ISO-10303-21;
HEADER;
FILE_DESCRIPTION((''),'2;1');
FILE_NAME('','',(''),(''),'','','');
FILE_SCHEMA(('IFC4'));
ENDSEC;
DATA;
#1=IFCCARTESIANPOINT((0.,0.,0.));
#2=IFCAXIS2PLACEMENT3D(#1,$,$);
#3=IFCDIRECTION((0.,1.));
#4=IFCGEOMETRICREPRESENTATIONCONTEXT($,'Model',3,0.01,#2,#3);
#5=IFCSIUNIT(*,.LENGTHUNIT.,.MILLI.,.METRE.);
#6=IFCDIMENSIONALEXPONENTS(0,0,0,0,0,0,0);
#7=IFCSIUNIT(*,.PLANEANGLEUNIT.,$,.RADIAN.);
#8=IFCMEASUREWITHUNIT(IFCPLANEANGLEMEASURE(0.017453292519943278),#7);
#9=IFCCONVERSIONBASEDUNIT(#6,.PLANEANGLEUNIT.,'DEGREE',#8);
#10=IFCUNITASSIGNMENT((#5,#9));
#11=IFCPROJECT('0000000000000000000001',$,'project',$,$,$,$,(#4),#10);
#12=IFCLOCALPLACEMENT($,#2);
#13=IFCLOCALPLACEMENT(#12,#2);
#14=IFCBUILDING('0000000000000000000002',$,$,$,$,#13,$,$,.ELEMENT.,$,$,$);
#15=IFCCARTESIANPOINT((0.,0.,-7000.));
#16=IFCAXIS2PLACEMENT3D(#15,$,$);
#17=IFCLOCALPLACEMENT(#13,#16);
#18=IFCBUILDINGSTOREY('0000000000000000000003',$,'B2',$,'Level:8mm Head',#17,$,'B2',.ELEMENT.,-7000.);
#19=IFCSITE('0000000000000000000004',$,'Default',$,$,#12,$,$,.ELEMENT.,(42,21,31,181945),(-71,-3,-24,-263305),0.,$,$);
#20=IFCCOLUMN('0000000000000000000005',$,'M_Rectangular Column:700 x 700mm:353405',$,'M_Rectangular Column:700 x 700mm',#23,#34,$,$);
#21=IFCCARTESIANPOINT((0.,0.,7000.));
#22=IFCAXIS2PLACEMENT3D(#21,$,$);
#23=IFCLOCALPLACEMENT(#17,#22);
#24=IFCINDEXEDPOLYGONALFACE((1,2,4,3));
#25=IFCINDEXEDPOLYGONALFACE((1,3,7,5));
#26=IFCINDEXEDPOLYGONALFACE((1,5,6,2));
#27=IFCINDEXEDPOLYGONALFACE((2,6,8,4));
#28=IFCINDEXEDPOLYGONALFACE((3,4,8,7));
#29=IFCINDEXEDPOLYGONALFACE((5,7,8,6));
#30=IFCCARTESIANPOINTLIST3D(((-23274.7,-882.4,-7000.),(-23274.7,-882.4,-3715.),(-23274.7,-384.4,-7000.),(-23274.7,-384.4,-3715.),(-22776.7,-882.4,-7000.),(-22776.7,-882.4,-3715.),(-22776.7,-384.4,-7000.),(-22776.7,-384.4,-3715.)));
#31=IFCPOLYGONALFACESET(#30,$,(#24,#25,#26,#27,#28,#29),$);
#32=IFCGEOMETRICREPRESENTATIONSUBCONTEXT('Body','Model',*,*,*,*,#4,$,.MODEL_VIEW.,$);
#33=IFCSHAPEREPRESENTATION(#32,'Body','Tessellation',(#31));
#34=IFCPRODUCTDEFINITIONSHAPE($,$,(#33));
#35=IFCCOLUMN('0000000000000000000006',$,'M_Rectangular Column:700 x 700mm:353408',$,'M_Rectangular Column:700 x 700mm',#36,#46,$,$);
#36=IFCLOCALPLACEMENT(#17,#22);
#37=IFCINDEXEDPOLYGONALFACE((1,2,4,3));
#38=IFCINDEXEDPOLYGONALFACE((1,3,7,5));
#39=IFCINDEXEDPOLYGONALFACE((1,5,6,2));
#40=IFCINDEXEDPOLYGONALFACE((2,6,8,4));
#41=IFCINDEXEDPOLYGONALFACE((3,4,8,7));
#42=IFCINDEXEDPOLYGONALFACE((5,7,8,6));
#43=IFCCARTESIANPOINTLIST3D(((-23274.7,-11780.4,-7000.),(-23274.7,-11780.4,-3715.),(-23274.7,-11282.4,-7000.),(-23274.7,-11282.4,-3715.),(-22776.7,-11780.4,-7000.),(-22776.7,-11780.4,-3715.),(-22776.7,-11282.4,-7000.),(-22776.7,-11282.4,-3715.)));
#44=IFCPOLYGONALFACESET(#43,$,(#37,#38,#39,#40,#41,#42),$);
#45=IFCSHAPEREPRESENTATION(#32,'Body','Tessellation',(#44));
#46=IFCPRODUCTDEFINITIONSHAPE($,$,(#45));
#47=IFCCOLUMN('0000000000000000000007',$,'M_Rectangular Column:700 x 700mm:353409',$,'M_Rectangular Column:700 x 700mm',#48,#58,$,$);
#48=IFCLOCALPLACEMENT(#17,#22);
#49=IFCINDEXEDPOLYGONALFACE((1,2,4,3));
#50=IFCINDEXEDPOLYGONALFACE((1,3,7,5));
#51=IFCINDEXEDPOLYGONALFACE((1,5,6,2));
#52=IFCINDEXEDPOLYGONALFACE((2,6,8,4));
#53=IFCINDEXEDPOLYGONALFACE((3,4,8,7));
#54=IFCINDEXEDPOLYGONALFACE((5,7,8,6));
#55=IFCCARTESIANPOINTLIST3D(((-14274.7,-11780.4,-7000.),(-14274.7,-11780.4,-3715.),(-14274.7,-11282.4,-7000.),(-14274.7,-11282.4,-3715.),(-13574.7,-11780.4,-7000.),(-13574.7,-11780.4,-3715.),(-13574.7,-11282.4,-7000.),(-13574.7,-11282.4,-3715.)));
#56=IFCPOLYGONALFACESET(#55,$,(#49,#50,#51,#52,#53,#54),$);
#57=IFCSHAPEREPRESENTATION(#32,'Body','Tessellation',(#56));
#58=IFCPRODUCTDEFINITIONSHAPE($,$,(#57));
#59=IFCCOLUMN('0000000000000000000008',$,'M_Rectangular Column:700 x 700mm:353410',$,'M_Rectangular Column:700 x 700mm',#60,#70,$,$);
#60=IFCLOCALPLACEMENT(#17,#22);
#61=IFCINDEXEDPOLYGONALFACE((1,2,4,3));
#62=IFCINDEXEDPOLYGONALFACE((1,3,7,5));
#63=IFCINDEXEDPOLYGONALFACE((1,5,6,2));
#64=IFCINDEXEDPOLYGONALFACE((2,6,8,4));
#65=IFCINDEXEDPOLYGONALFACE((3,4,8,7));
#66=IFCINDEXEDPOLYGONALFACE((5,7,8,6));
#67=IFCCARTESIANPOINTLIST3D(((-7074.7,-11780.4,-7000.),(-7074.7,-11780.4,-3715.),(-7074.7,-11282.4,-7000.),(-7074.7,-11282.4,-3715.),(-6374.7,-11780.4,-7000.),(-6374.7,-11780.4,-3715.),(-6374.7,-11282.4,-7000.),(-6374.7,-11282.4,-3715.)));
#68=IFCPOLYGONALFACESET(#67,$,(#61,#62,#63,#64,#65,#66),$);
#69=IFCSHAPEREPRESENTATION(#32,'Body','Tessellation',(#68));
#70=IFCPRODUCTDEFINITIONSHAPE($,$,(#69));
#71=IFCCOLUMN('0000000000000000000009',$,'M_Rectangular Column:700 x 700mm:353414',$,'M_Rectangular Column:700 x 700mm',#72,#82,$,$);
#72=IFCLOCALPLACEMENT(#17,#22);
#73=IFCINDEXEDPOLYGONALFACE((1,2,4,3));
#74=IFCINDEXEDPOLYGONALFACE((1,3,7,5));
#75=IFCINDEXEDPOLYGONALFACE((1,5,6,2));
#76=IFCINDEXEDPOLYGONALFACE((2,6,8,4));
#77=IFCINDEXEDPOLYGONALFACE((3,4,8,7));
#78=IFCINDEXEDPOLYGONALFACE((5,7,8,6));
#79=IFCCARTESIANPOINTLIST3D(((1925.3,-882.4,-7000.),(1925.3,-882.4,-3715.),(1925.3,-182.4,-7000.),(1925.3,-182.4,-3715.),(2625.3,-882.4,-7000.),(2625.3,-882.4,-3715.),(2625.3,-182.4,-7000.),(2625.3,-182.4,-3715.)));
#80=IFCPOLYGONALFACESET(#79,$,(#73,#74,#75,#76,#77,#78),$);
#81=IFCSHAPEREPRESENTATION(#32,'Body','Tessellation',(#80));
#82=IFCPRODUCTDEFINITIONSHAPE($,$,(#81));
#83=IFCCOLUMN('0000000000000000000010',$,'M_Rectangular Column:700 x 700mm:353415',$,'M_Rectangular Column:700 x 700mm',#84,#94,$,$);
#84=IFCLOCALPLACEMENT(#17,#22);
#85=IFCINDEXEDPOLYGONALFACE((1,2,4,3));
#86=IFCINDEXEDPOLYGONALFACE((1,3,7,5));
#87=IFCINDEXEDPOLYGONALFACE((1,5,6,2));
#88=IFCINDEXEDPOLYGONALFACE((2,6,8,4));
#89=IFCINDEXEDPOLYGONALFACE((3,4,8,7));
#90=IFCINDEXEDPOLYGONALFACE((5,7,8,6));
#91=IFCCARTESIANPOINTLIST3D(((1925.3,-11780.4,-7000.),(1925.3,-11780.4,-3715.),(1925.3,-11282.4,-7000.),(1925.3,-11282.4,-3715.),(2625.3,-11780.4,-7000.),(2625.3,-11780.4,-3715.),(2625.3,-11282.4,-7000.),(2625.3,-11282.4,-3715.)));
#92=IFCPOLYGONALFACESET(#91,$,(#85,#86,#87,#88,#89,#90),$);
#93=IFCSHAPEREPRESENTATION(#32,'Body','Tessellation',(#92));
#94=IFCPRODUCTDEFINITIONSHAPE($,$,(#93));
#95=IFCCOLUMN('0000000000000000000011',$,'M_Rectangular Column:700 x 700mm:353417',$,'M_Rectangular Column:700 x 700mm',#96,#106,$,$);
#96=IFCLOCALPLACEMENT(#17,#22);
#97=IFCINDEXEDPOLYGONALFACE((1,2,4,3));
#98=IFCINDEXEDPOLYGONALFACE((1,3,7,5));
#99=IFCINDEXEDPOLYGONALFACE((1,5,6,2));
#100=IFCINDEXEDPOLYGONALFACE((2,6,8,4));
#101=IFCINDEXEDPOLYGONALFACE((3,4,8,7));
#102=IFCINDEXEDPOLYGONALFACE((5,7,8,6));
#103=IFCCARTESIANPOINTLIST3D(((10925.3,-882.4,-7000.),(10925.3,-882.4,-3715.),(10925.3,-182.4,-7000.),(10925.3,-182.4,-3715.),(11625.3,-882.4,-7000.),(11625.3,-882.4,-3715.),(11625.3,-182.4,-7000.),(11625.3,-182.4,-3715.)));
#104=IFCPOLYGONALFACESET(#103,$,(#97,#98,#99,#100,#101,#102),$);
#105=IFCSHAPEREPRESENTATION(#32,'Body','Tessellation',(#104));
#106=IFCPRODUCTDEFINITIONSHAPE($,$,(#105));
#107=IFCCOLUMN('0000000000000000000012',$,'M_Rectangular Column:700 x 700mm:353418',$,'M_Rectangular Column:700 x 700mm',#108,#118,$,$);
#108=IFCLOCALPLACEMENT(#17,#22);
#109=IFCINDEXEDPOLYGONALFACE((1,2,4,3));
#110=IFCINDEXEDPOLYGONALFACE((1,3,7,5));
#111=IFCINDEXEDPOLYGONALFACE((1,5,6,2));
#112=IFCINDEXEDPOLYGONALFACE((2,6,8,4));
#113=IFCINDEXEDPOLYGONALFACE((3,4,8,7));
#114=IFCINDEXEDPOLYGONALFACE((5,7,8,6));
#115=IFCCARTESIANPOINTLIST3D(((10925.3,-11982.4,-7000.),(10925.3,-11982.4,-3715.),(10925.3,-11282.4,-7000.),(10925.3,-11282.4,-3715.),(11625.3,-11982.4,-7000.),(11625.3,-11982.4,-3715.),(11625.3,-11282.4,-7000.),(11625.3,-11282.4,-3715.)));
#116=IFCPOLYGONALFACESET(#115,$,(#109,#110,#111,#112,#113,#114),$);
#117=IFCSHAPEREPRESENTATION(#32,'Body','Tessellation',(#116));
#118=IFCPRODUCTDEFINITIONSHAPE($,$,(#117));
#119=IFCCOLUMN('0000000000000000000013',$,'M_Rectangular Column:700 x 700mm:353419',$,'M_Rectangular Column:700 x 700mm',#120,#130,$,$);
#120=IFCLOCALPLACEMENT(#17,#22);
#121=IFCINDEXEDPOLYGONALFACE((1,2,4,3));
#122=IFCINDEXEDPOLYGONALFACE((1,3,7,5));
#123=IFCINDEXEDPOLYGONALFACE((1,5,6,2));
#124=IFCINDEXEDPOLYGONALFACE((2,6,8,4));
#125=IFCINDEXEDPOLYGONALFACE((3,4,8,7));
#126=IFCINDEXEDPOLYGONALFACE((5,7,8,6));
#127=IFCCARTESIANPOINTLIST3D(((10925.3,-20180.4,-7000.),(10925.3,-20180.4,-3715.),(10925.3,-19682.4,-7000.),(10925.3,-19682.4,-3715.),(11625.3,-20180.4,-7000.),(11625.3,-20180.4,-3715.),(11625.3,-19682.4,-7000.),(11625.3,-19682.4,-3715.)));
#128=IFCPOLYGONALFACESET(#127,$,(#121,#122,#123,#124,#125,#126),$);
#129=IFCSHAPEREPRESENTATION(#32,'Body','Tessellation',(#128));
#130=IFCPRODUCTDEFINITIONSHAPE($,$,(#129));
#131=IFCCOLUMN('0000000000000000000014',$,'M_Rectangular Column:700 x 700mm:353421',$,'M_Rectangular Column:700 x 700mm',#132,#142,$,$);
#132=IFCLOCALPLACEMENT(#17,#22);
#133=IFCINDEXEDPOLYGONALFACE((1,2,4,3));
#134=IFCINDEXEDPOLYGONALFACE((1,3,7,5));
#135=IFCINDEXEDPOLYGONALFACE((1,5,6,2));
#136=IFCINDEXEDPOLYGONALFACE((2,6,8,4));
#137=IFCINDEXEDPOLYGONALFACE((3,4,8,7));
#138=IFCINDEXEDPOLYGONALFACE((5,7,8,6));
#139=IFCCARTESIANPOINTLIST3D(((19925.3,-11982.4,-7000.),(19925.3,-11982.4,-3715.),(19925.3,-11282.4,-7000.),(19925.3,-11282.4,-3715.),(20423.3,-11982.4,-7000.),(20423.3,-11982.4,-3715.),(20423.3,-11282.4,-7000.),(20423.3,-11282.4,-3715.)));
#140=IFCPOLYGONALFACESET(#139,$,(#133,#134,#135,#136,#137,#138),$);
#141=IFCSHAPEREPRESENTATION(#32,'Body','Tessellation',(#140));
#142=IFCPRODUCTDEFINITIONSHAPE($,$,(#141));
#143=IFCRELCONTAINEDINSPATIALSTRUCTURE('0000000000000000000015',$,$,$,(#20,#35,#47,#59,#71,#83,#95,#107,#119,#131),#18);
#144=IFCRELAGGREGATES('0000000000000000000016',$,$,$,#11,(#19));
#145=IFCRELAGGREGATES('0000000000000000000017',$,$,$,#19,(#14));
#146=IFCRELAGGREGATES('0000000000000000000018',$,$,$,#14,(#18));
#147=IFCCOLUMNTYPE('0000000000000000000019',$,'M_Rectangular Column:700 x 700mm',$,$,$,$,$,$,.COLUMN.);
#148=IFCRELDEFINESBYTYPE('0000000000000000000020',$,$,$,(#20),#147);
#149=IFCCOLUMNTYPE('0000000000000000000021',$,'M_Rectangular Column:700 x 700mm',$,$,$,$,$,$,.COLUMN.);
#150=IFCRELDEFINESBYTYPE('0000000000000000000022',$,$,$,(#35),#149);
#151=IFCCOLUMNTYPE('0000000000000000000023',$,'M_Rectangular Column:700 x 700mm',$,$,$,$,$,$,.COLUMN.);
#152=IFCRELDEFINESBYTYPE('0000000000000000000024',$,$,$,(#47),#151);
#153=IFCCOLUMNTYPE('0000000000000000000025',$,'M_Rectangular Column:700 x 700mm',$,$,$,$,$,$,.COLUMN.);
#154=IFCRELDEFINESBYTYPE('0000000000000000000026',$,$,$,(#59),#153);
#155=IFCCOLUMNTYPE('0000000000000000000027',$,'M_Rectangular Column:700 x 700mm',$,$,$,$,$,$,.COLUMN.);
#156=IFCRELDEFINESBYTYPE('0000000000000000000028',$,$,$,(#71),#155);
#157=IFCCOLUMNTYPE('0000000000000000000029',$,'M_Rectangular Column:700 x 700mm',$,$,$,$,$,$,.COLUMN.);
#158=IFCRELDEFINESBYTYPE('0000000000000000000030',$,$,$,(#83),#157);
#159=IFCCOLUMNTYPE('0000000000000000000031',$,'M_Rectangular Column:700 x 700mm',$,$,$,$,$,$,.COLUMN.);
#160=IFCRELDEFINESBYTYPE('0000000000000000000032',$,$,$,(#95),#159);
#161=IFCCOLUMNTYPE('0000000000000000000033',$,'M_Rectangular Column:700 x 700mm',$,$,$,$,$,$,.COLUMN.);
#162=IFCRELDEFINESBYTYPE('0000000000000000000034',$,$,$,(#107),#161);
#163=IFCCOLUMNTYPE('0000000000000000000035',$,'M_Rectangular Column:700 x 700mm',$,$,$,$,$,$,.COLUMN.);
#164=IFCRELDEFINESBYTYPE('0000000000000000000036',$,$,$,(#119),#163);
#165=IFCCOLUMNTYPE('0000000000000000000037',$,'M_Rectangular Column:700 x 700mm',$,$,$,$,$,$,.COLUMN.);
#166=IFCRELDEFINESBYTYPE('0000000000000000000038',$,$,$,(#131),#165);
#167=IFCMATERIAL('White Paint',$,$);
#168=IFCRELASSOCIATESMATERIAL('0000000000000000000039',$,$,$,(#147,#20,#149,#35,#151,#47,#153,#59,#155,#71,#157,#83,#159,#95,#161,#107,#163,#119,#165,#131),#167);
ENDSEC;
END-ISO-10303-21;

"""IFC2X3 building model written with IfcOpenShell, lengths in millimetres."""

from ifc_helpers import new_model, entity, si_unit, converted_unit, direction, frame, frame_2d, origin, origin_2d_with_axis, place, context, subcontext, project, spatial, rectangle, extrude, source, transform, mapped, material, type_object, type_shapes, element, save


model = new_model("IFC2X3")

# Units and contexts
model_context = context("Model", 3, precision=0.01, world=origin(), true_north=direction((0.0, 1.0)))
body_context = subcontext(model_context, "Body", "Model", "MODEL_VIEW")
ifc_project = project(units=[si_unit("LENGTHUNIT", "METRE", prefix="MILLI"), converted_unit("PLANEANGLEUNIT", "DEGREE", entity("IfcPlaneAngleMeasure", 0.017453292519943278), si_unit("PLANEANGLEUNIT", "RADIAN"), dimensions=[0, 0, 0, 0, 0, 0, 0])], contexts=[model_context])

# Site, building, storey
site_placement = place(None, origin())
site = spatial("IfcSite", under=ifc_project, at=site_placement, Name="Default", CompositionType="ELEMENT", RefLatitude=(42, 21, 31, 181945), RefLongitude=(-71, -3, -24, -263305), RefElevation=0.0)
building_placement = place(site_placement, origin())
building = spatial("IfcBuilding", under=site, at=building_placement, CompositionType="ELEMENT")
storey_placement = place(building_placement, frame((0.0, 0.0, -7000.0)))
storey = spatial("IfcBuildingStorey", under=building, at=storey_placement, Name="B2", ObjectType="Level:8mm Head", LongName="B2", CompositionType="ELEMENT", Elevation=-7000.0)

# Columns
ifc_material_1 = material(Name="White Paint")
column_type_1 = type_object("IfcColumnType", Name="M_Rectangular Column:700 x 700mm", PredefinedType="COLUMN", material=ifc_material_1)
shared_shape_1 = source(origin(), body_context, "Body", "SweptSolid", [
    extrude(rectangle(XDim=498.0, YDim=498.0, at=frame_2d((0.0, 0.0), x_axis=(1.0, 0.0))), frame((-23025.7, -633.4, -7000.0), z_axis=(0.0, 0.0, 1.0), x_axis=(0.0, 1.0, 0.0)), (0.0, 0.0, 1.0), 3285.0),
])
type_shapes(column_type_1, [shared_shape_1])
column_1_placement = place(storey_placement, frame((0.0, 0.0, 7000.0)))
element("IfcColumn", 1, at=column_1_placement, inside=storey, type_object=column_type_1, material=ifc_material_1, Name="M_Rectangular Column:700 x 700mm:353405", ObjectType="M_Rectangular Column:700 x 700mm", context=body_context, shape_type="MappedRepresentation", body=[
    mapped(shared_shape_1, transform((0.0, 0.0, 0.0), scale=1.0)),
])
column_type_2 = type_object("IfcColumnType", Name="M_Rectangular Column:700 x 700mm", PredefinedType="COLUMN", material=ifc_material_1)
shared_shape_2 = source(origin(), body_context, "Body", "SweptSolid", [
    extrude(rectangle(XDim=498.0, YDim=498.0, at=frame_2d((0.0, 0.0), x_axis=(1.0, 0.0))), frame((-23025.7, -11531.4, -7000.0)), (0.0, 0.0, 1.0), 3285.0),
])
type_shapes(column_type_2, [shared_shape_2])
column_2_placement = place(storey_placement, frame((0.0, 0.0, 7000.0)))
element("IfcColumn", 2, at=column_2_placement, inside=storey, type_object=column_type_2, material=ifc_material_1, Name="M_Rectangular Column:700 x 700mm:353408", ObjectType="M_Rectangular Column:700 x 700mm", context=body_context, shape_type="MappedRepresentation", body=[
    mapped(shared_shape_2, transform((0.0, 0.0, 0.0), scale=1.0)),
])
column_type_3 = type_object("IfcColumnType", Name="M_Rectangular Column:700 x 700mm", PredefinedType="COLUMN", material=ifc_material_1)
shared_shape_3 = source(origin(), body_context, "Body", "SweptSolid", [
    extrude(rectangle(XDim=3285.0, YDim=498.0, at=origin_2d_with_axis()), frame((-14274.7, -11531.4, -5357.5), z_axis=(1.0, 0.0, 0.0), x_axis=(0.0, 0.0, 1.0)), (0.0, 0.0, 1.0), 700.0),
])
type_shapes(column_type_3, [shared_shape_3])
column_3_placement = place(storey_placement, frame((0.0, 0.0, 7000.0)))
element("IfcColumn", 3, at=column_3_placement, inside=storey, type_object=column_type_3, material=ifc_material_1, Name="M_Rectangular Column:700 x 700mm:353409", ObjectType="M_Rectangular Column:700 x 700mm", context=body_context, shape_type="MappedRepresentation", body=[
    mapped(shared_shape_3, transform((0.0, 0.0, 0.0), scale=1.0)),
])
column_type_4 = type_object("IfcColumnType", Name="M_Rectangular Column:700 x 700mm", PredefinedType="COLUMN", material=ifc_material_1)
shared_shape_4 = source(origin(), body_context, "Body", "SweptSolid", [
    extrude(rectangle(XDim=3285.0, YDim=498.0, at=origin_2d_with_axis()), frame((-7074.7, -11531.4, -5357.5), z_axis=(1.0, 0.0, 0.0), x_axis=(0.0, 0.0, 1.0)), (0.0, 0.0, 1.0), 700.0),
])
type_shapes(column_type_4, [shared_shape_4])
column_4_placement = place(storey_placement, frame((0.0, 0.0, 7000.0)))
element("IfcColumn", 4, at=column_4_placement, inside=storey, type_object=column_type_4, material=ifc_material_1, Name="M_Rectangular Column:700 x 700mm:353410", ObjectType="M_Rectangular Column:700 x 700mm", context=body_context, shape_type="MappedRepresentation", body=[
    mapped(shared_shape_4, transform((0.0, 0.0, 0.0), scale=1.0)),
])
column_type_5 = type_object("IfcColumnType", Name="M_Rectangular Column:700 x 700mm", PredefinedType="COLUMN", material=ifc_material_1)
shared_shape_5 = source(origin(), body_context, "Body", "SweptSolid", [
    extrude(rectangle(XDim=700.0, YDim=700.0, at=frame_2d((0.0, 0.0), x_axis=(1.0, 0.0))), frame((2275.3, -532.4, -7000.0), z_axis=(0.0, 0.0, 1.0), x_axis=(-1.0, 0.0, 0.0)), (0.0, 0.0, 1.0), 3285.0),
])
type_shapes(column_type_5, [shared_shape_5])
column_5_placement = place(storey_placement, frame((0.0, 0.0, 7000.0)))
element("IfcColumn", 5, at=column_5_placement, inside=storey, type_object=column_type_5, material=ifc_material_1, Name="M_Rectangular Column:700 x 700mm:353414", ObjectType="M_Rectangular Column:700 x 700mm", context=body_context, shape_type="MappedRepresentation", body=[
    mapped(shared_shape_5, transform((0.0, 0.0, 0.0), scale=1.0)),
])
column_type_6 = type_object("IfcColumnType", Name="M_Rectangular Column:700 x 700mm", PredefinedType="COLUMN", material=ifc_material_1)
shared_shape_6 = source(origin(), body_context, "Body", "SweptSolid", [
    extrude(rectangle(XDim=3285.0, YDim=498.0, at=frame_2d((0.0, 0.0), x_axis=(1.0, 0.0))), frame((1925.3, -11531.4, -5357.5), z_axis=(1.0, 0.0, 0.0), x_axis=(0.0, 0.0, 1.0)), (0.0, 0.0, 1.0), 700.0),
])
type_shapes(column_type_6, [shared_shape_6])
column_6_placement = place(storey_placement, frame((0.0, 0.0, 7000.0)))
element("IfcColumn", 6, at=column_6_placement, inside=storey, type_object=column_type_6, material=ifc_material_1, Name="M_Rectangular Column:700 x 700mm:353415", ObjectType="M_Rectangular Column:700 x 700mm", context=body_context, shape_type="MappedRepresentation", body=[
    mapped(shared_shape_6, transform((0.0, 0.0, 0.0), scale=1.0)),
])
column_type_7 = type_object("IfcColumnType", Name="M_Rectangular Column:700 x 700mm", PredefinedType="COLUMN", material=ifc_material_1)
shared_shape_7 = source(origin(), body_context, "Body", "SweptSolid", [
    extrude(rectangle(XDim=700.0, YDim=700.0, at=origin_2d_with_axis()), frame((11275.3, -532.4, -7000.0), z_axis=(0.0, 0.0, 1.0), x_axis=(-1.0, 0.0, 0.0)), (0.0, 0.0, 1.0), 3285.0),
])
type_shapes(column_type_7, [shared_shape_7])
column_7_placement = place(storey_placement, frame((0.0, 0.0, 7000.0)))
element("IfcColumn", 7, at=column_7_placement, inside=storey, type_object=column_type_7, material=ifc_material_1, Name="M_Rectangular Column:700 x 700mm:353417", ObjectType="M_Rectangular Column:700 x 700mm", context=body_context, shape_type="MappedRepresentation", body=[
    mapped(shared_shape_7, transform((0.0, 0.0, 0.0), scale=1.0)),
])
column_type_8 = type_object("IfcColumnType", Name="M_Rectangular Column:700 x 700mm", PredefinedType="COLUMN", material=ifc_material_1)
shared_shape_8 = source(origin(), body_context, "Body", "SweptSolid", [
    extrude(rectangle(XDim=700.0, YDim=700.0, at=frame_2d((0.0, 0.0), x_axis=(1.0, 0.0))), frame((11275.3, -11632.4, -7000.0), z_axis=(0.0, 0.0, 1.0), x_axis=(-1.0, 0.0, 0.0)), (0.0, 0.0, 1.0), 3285.0),
])
type_shapes(column_type_8, [shared_shape_8])
column_8_placement = place(storey_placement, frame((0.0, 0.0, 7000.0)))
element("IfcColumn", 8, at=column_8_placement, inside=storey, type_object=column_type_8, material=ifc_material_1, Name="M_Rectangular Column:700 x 700mm:353418", ObjectType="M_Rectangular Column:700 x 700mm", context=body_context, shape_type="MappedRepresentation", body=[
    mapped(shared_shape_8, transform((0.0, 0.0, 0.0), scale=1.0)),
])
column_type_9 = type_object("IfcColumnType", Name="M_Rectangular Column:700 x 700mm", PredefinedType="COLUMN", material=ifc_material_1)
shared_shape_9 = source(origin(), body_context, "Body", "SweptSolid", [
    extrude(rectangle(XDim=3285.0, YDim=498.0, at=origin_2d_with_axis()), frame((10925.3, -19931.4, -5357.5), z_axis=(1.0, 0.0, 0.0), x_axis=(0.0, 0.0, 1.0)), (0.0, 0.0, 1.0), 700.0),
])
type_shapes(column_type_9, [shared_shape_9])
column_9_placement = place(storey_placement, frame((0.0, 0.0, 7000.0)))
element("IfcColumn", 9, at=column_9_placement, inside=storey, type_object=column_type_9, material=ifc_material_1, Name="M_Rectangular Column:700 x 700mm:353419", ObjectType="M_Rectangular Column:700 x 700mm", context=body_context, shape_type="MappedRepresentation", body=[
    mapped(shared_shape_9, transform((0.0, 0.0, 0.0), scale=1.0)),
])
column_type_10 = type_object("IfcColumnType", Name="M_Rectangular Column:700 x 700mm", PredefinedType="COLUMN", material=ifc_material_1)
shared_shape_10 = source(origin(), body_context, "Body", "SweptSolid", [
    extrude(rectangle(XDim=3285.0, YDim=498.0, at=frame_2d((0.0, 0.0), x_axis=(1.0, 0.0))), frame((20174.3, -11982.4, -5357.5), z_axis=(0.0, 1.0, 0.0), x_axis=(0.0, 0.0, 1.0)), (0.0, 0.0, 1.0), 700.0),
])
type_shapes(column_type_10, [shared_shape_10])
column_10_placement = place(storey_placement, frame((0.0, 0.0, 7000.0)))
element("IfcColumn", 10, at=column_10_placement, inside=storey, type_object=column_type_10, material=ifc_material_1, Name="M_Rectangular Column:700 x 700mm:353421", ObjectType="M_Rectangular Column:700 x 700mm", context=body_context, shape_type="MappedRepresentation", body=[
    mapped(shared_shape_10, transform((0.0, 0.0, 0.0), scale=1.0)),
])

save(model, "model.ifc")
